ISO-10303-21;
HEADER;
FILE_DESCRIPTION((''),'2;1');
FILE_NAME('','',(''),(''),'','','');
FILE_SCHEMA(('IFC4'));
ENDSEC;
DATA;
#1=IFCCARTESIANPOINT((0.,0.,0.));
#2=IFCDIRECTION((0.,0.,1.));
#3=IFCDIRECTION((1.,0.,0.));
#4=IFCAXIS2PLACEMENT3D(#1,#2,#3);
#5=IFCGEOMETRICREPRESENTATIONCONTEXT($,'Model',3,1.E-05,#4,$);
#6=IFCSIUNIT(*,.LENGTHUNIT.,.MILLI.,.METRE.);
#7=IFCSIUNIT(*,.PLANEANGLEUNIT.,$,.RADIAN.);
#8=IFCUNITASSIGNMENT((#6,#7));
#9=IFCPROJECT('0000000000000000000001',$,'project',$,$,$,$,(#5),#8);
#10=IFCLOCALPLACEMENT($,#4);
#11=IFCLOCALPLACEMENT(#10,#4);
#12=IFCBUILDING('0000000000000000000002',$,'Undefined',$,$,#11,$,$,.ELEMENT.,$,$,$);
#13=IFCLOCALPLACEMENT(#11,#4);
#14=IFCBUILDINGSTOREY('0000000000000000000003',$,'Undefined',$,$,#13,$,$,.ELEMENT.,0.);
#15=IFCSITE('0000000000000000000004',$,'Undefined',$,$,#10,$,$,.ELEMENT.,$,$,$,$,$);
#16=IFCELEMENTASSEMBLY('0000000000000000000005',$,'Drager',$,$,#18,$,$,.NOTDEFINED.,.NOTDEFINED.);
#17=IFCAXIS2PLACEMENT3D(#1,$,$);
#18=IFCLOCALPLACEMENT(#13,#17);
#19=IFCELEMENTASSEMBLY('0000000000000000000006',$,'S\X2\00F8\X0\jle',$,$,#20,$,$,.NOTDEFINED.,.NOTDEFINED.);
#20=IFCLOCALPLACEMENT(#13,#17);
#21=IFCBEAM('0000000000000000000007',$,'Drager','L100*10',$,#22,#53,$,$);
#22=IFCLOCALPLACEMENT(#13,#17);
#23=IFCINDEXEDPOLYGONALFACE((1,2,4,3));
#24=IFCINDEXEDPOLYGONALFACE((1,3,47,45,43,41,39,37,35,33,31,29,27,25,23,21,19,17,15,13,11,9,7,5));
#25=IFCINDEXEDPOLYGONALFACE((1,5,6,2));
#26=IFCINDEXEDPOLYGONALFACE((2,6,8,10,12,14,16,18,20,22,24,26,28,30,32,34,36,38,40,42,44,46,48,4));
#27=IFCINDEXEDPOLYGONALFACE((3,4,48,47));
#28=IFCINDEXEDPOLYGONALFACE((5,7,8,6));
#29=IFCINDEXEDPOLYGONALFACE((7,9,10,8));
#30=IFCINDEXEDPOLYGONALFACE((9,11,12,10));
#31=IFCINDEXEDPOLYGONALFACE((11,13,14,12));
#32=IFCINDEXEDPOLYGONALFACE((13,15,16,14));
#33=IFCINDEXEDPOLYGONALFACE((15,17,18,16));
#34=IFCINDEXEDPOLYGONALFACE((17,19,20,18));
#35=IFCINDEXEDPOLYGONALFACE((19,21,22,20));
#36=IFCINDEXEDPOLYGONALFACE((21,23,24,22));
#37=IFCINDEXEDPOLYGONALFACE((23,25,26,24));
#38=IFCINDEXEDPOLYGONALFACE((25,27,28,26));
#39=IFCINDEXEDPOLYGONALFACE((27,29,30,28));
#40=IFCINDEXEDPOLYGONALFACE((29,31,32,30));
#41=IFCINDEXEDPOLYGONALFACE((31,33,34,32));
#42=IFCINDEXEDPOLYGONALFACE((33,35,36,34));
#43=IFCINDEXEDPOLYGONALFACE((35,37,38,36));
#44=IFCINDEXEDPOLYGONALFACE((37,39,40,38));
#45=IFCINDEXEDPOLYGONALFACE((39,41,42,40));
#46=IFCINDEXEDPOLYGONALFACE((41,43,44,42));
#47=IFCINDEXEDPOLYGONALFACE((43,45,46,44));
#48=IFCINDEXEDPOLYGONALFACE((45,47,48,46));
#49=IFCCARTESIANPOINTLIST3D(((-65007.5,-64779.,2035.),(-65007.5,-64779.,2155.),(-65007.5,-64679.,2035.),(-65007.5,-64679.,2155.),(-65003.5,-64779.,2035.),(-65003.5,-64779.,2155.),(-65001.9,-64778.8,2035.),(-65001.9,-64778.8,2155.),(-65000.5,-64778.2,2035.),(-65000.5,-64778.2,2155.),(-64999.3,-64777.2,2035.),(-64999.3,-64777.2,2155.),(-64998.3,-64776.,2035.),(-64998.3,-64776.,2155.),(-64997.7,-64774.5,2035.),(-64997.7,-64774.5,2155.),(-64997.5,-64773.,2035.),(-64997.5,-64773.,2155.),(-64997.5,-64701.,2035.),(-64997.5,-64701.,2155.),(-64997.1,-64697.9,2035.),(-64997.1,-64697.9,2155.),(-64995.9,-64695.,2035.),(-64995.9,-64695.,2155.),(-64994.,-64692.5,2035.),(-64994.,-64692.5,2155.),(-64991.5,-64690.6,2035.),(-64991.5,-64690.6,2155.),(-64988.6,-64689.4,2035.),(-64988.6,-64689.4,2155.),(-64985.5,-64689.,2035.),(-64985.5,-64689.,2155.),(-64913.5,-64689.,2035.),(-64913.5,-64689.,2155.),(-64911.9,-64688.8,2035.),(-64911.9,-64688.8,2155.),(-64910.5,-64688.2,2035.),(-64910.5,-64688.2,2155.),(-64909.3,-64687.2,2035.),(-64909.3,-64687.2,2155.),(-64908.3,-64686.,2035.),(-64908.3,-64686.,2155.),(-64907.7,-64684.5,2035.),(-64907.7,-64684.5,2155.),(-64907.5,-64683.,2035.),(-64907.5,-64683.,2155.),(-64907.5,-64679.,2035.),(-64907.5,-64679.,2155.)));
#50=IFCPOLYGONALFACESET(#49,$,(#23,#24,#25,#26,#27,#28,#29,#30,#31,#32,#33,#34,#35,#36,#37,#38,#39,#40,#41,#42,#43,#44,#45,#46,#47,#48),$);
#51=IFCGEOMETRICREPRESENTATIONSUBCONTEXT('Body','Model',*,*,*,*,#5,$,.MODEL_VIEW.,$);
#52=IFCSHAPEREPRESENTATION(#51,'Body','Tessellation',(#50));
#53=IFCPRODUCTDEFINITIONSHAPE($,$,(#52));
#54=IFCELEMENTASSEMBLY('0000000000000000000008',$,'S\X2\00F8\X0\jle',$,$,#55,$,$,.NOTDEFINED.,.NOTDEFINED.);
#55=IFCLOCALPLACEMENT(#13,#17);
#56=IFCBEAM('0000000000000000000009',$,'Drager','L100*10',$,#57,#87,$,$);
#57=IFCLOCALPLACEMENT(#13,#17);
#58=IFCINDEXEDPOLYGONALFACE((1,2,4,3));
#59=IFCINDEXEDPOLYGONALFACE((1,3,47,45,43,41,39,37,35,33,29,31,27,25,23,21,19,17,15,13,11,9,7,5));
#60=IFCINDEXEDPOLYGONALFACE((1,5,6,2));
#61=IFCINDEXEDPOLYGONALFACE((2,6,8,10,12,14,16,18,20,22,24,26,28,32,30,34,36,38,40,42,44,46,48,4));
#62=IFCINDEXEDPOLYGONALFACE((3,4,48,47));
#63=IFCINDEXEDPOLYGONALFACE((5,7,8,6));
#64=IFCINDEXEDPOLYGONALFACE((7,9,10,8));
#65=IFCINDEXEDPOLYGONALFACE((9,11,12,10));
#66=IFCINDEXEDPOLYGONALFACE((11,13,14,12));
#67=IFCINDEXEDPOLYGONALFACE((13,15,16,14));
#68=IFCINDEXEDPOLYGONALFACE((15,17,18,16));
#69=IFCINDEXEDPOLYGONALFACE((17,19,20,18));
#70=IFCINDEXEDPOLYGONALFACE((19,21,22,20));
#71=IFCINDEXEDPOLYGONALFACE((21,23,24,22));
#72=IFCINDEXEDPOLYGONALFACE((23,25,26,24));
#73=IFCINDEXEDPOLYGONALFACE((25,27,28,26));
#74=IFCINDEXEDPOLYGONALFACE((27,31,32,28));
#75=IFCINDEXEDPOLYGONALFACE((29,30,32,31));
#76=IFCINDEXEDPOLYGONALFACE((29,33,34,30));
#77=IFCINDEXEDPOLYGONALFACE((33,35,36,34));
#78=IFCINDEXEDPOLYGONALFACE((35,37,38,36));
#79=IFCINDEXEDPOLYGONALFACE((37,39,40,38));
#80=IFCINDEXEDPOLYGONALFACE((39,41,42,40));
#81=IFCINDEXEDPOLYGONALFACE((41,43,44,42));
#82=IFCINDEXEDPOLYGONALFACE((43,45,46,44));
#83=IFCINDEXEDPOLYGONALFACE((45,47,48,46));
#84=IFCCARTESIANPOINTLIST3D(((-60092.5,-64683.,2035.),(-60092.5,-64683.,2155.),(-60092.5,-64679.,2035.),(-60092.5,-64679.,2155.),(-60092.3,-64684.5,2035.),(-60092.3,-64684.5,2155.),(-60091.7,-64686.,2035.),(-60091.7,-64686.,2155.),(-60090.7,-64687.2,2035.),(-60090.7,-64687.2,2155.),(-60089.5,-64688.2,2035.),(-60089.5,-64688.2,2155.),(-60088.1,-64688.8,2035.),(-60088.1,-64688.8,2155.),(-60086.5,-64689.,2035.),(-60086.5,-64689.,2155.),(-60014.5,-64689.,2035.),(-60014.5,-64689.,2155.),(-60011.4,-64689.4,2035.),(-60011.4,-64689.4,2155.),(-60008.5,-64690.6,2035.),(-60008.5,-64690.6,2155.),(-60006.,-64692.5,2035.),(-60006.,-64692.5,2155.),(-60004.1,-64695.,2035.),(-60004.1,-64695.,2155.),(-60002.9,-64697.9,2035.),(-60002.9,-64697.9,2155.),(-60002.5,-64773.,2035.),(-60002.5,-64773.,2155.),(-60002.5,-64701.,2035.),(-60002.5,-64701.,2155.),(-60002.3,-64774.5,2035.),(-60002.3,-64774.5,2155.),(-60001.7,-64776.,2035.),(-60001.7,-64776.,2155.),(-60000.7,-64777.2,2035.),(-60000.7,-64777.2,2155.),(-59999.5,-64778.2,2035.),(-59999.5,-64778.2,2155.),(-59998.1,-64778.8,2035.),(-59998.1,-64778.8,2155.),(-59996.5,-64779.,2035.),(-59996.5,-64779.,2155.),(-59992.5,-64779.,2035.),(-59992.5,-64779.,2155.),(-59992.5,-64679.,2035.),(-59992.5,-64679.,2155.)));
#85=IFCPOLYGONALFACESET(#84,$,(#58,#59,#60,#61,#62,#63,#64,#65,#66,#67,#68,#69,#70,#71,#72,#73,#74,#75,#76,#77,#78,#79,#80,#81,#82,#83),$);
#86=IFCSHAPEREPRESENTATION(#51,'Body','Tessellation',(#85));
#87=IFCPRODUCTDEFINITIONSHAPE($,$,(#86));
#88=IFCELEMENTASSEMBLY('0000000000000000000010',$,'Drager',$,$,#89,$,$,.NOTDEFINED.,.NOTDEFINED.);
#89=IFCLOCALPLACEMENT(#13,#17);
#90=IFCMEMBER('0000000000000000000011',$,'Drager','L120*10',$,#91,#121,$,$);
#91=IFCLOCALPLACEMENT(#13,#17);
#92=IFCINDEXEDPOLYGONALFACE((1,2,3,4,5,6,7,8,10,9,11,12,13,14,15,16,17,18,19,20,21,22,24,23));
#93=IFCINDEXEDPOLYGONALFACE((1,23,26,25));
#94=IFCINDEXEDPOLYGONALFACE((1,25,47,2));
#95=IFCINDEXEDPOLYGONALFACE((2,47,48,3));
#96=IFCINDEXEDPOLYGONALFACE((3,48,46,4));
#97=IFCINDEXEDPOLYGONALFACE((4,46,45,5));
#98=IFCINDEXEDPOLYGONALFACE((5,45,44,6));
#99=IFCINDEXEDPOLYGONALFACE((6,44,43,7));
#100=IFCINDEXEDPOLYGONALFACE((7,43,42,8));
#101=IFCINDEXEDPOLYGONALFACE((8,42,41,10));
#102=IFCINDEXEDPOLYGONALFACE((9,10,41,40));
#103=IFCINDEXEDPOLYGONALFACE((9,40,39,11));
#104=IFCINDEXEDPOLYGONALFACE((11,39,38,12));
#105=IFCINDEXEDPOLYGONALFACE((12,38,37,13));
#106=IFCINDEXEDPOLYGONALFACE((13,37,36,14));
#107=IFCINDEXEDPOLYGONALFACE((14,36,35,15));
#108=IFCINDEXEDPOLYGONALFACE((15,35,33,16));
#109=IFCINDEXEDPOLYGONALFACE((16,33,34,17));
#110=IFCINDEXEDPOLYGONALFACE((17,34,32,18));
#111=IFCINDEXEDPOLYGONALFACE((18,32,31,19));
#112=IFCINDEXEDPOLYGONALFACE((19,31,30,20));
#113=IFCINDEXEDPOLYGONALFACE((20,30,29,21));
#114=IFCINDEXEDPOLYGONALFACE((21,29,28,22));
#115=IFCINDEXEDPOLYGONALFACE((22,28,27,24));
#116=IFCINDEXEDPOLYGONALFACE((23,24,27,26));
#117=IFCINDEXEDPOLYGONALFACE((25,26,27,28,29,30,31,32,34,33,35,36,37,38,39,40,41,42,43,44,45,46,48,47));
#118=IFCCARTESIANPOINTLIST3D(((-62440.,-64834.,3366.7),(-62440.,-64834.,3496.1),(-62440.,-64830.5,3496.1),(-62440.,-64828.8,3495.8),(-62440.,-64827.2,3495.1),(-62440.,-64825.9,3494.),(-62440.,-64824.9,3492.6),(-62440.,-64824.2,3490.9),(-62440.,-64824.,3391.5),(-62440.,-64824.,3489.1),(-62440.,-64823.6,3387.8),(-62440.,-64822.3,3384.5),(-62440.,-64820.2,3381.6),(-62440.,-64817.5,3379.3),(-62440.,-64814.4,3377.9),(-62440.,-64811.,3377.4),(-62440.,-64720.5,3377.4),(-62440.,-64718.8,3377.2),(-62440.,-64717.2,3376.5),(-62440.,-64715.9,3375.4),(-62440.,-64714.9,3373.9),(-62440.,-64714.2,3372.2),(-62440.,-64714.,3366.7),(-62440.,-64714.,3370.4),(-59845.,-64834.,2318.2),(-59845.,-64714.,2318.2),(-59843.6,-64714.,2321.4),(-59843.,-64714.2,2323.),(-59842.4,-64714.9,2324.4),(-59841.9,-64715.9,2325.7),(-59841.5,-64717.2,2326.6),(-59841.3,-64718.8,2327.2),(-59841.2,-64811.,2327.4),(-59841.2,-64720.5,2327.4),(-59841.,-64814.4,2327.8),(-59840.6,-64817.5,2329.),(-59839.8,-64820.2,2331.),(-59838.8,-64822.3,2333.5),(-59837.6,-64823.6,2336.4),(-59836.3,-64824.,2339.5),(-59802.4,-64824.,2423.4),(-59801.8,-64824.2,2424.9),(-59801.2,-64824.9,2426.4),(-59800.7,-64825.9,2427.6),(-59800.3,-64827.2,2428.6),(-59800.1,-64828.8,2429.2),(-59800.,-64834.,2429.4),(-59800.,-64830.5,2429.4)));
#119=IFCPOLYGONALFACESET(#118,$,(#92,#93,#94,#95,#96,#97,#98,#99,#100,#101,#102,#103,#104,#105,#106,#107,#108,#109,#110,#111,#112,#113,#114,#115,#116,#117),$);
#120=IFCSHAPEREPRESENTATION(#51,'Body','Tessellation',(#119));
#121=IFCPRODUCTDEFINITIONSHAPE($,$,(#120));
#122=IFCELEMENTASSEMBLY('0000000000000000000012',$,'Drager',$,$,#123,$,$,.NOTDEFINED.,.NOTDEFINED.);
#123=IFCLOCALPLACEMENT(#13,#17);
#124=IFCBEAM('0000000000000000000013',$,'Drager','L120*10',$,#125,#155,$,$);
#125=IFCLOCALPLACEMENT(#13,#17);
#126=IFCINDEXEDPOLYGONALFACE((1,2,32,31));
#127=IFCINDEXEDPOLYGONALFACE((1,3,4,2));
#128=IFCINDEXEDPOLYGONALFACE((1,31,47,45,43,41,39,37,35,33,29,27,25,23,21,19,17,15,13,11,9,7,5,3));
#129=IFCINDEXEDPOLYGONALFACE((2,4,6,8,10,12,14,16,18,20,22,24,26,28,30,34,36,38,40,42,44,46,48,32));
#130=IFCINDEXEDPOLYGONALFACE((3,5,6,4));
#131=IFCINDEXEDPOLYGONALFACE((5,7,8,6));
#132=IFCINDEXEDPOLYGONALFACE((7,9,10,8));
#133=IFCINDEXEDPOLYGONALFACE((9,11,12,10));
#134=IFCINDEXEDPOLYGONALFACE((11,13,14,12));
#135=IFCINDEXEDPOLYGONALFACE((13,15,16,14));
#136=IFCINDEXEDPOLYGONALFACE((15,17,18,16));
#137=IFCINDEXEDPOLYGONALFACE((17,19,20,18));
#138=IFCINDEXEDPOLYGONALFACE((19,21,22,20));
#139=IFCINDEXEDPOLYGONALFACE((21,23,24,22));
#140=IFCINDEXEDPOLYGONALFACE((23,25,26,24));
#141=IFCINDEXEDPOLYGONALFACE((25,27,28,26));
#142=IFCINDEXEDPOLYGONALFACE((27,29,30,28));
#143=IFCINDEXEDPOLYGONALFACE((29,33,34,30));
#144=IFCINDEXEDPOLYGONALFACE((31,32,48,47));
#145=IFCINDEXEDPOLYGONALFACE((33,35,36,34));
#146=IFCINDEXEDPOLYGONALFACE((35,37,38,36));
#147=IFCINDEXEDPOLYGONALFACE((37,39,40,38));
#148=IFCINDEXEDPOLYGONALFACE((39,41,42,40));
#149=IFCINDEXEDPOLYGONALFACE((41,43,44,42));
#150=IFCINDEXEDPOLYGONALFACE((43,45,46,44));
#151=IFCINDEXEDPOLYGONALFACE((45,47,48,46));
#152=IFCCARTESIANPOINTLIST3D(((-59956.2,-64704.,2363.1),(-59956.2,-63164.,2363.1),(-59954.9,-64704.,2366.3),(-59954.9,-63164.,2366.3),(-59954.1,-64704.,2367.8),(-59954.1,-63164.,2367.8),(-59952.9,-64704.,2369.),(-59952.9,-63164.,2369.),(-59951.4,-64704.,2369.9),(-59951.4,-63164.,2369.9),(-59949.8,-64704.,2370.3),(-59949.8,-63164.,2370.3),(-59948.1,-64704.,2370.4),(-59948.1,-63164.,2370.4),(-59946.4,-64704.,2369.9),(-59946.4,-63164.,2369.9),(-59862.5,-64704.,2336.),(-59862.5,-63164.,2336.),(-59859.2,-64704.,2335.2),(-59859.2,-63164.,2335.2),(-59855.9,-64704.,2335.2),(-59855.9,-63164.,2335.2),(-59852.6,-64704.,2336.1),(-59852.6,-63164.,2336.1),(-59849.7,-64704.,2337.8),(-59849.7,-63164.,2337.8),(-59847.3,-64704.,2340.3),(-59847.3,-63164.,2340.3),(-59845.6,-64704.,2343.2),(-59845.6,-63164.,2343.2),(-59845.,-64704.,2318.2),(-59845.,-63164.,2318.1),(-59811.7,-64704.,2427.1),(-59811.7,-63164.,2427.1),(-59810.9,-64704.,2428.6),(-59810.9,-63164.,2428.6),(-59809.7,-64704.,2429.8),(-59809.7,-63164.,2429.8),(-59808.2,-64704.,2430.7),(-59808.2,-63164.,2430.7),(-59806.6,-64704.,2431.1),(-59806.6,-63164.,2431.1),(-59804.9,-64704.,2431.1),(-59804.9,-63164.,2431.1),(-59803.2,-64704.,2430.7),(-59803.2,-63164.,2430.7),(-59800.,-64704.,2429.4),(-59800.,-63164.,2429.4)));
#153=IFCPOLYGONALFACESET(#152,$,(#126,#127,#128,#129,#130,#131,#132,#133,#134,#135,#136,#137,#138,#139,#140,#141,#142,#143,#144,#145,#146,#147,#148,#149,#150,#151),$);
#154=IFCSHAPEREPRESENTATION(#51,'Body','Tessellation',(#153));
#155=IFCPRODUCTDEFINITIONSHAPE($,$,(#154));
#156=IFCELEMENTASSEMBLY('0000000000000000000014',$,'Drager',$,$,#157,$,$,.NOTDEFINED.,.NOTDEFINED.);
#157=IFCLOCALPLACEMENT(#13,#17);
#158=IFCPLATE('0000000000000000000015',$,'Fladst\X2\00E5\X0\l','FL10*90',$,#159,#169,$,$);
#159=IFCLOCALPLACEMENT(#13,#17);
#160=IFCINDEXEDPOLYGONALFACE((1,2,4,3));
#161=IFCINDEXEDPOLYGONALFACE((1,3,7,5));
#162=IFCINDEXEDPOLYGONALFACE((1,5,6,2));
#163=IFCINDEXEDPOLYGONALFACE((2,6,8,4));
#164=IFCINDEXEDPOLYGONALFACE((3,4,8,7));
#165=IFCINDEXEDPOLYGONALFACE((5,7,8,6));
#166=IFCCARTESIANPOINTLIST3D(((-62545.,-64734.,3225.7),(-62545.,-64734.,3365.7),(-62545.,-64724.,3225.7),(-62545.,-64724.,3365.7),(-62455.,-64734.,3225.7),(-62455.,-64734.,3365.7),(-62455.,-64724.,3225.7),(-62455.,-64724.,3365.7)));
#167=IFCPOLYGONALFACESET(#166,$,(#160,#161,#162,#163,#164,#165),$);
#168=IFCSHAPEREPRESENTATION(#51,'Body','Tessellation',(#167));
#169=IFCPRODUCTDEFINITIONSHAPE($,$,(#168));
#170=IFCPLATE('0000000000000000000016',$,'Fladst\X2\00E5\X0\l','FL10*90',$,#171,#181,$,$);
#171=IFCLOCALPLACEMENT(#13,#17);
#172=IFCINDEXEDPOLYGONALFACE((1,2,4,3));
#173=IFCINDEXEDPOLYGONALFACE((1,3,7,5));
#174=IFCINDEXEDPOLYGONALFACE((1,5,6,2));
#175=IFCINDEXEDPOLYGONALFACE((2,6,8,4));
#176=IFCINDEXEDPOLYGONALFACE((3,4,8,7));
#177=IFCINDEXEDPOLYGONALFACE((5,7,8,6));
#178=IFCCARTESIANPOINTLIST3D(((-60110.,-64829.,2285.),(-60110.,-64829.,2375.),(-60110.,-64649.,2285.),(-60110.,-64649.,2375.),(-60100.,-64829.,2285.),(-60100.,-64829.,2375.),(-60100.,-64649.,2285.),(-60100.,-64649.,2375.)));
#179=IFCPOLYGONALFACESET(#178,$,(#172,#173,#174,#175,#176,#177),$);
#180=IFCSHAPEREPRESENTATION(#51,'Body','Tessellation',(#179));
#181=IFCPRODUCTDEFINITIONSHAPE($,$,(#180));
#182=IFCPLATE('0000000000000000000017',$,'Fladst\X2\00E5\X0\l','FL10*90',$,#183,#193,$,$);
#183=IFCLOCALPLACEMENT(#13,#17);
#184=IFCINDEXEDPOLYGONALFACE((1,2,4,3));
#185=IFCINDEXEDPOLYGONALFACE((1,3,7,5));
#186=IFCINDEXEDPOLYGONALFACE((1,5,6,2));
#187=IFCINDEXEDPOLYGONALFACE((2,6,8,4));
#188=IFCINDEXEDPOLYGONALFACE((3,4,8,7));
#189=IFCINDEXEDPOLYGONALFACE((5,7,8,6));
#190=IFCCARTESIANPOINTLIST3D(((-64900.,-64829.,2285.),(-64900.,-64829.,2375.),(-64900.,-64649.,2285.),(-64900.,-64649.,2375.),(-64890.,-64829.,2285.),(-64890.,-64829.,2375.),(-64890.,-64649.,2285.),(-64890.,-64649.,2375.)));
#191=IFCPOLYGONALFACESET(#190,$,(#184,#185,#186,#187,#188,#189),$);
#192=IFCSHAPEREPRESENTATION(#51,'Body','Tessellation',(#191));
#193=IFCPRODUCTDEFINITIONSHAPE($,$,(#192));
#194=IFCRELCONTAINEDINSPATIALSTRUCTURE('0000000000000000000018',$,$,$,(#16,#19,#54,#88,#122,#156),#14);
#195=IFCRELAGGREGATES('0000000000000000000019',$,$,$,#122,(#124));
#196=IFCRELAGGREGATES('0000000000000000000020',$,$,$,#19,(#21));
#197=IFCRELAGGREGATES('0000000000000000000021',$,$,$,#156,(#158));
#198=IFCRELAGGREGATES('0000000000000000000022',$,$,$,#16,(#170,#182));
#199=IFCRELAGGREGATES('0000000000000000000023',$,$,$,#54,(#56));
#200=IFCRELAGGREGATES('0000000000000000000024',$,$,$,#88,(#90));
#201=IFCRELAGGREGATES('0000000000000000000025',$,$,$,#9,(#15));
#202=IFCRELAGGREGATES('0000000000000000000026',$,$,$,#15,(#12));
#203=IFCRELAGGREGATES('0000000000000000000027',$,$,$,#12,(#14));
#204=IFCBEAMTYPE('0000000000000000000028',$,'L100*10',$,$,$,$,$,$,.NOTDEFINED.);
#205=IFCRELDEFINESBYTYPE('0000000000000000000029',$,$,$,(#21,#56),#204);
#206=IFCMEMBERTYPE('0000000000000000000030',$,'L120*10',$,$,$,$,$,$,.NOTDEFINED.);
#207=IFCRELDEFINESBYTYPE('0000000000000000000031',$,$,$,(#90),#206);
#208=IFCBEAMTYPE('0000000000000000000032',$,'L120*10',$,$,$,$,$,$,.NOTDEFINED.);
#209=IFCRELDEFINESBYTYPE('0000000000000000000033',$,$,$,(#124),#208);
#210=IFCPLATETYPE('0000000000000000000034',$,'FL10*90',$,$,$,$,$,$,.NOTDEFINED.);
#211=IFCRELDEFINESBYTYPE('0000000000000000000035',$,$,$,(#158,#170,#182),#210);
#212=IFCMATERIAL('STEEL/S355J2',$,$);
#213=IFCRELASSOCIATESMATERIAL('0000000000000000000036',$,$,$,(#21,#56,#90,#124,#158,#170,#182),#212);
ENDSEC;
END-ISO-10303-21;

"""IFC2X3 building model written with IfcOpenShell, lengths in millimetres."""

from ifc_helpers import new_model, si_unit, frame, origin_with_axes, origin_2d_with_axis, place, context, subcontext, project, spatial, polyline, l_section, outline, extrude, clip, halfspace, material, type_object, element, aggregate, save


model = new_model("IFC2X3")

# Units and contexts
model_context = context("Model", 3, precision=1e-05, world=origin_with_axes())
body_context = subcontext(model_context, "Body", "Model", "MODEL_VIEW")
ifc_project = project(units=[si_unit("LENGTHUNIT", "METRE", prefix="MILLI"), si_unit("PLANEANGLEUNIT", "RADIAN")], contexts=[model_context])

# Site, building, storey
site_placement = place(None, origin_with_axes())
site = spatial("IfcSite", under=ifc_project, at=site_placement, Name="Undefined", CompositionType="ELEMENT")
building_placement = place(site_placement, origin_with_axes())
building = spatial("IfcBuilding", under=site, at=building_placement, Name="Undefined", CompositionType="ELEMENT")
storey_placement = place(building_placement, origin_with_axes())
storey = spatial("IfcBuildingStorey", under=building, at=storey_placement, Name="Undefined", CompositionType="ELEMENT", Elevation=0.0)

# Element assemblies, beams
assembly_1_placement = place(storey_placement, origin_with_axes())
assembly_1 = element("IfcElementAssembly", 1, at=assembly_1_placement, inside=storey, Name="Drager", AssemblyPlace="NOTDEFINED", PredefinedType="NOTDEFINED")
assembly_2_placement = place(storey_placement, origin_with_axes())
assembly_2 = element("IfcElementAssembly", 2, at=assembly_2_placement, inside=storey, Name="Søjle", AssemblyPlace="NOTDEFINED", PredefinedType="NOTDEFINED")
ifc_material_1 = material(Name="STEEL/S355J2")
beam_type_1 = type_object("IfcBeamType", Name="L100*10", PredefinedType="NOTDEFINED")
beam_1_placement = place(assembly_2_placement, frame((-64957.5, -64729.0, 2155.0), z_axis=(1.0, 0.0, 0.0), x_axis=(0.0, 0.0, -1.0)))
beam_1 = element("IfcBeam", 3, at=beam_1_placement, type_object=beam_type_1, material=ifc_material_1, Name="Drager", Description="L100*10", context=body_context, shape_type="SweptSolid", body=[
    extrude(l_section(Depth=100.0, Width=100.0, Thickness=10.0, FilletRadius=12.0, EdgeRadius=6.0, at=origin_2d_with_axis()), frame((120.0, 0.0, 0.0), z_axis=(-1.0, 0.0, 0.0), x_axis=(0.0, -1.0, 0.0)), (0.0, 0.0, 1.0), 120.0),
])
assembly_3_placement = place(storey_placement, origin_with_axes())
assembly_3 = element("IfcElementAssembly", 4, at=assembly_3_placement, inside=storey, Name="Søjle", AssemblyPlace="NOTDEFINED", PredefinedType="NOTDEFINED")
beam_2_placement = place(assembly_3_placement, frame((-60042.5, -64729.0, 2035.0), z_axis=(-1.0, 0.0, 0.0), x_axis=(0.0, 0.0, 1.0)))
beam_2 = element("IfcBeam", 5, at=beam_2_placement, type_object=beam_type_1, material=ifc_material_1, Name="Drager", Description="L100*10", context=body_context, shape_type="SweptSolid", body=[
    extrude(l_section(Depth=100.0, Width=100.0, Thickness=10.0, FilletRadius=12.0, EdgeRadius=6.0, at=origin_2d_with_axis()), frame((120.0, 0.0, 0.0), z_axis=(-1.0, 0.0, 0.0), x_axis=(0.0, -1.0, 0.0)), (0.0, 0.0, 1.0), 120.0),
])

# Element assembly, member
assembly_4_placement = place(storey_placement, origin_with_axes())
assembly_4 = element("IfcElementAssembly", 6, at=assembly_4_placement, inside=storey, Name="Drager", AssemblyPlace="NOTDEFINED", PredefinedType="NOTDEFINED")
member_type = type_object("IfcMemberType", Name="L120*10", PredefinedType="NOTDEFINED")
member_placement = place(assembly_4_placement, frame((-62494.1, -64774.0, 3453.2), z_axis=(0.0, 1.0, 0.0), x_axis=(0.927179, 0.0, -0.374619)))
member = element("IfcMember", 7, at=member_placement, type_object=member_type, material=ifc_material_1, Name="Drager", Description="L120*10", context=body_context, shape_type="Clipping", body=[
    clip(clip(extrude(l_section(Depth=120.0, Width=120.0, Thickness=10.0, FilletRadius=13.0, EdgeRadius=6.5, at=origin_2d_with_axis()), frame((2948.0, 0.0, 0.0), z_axis=(-1.0, 0.0, 0.0), x_axis=(0.0, -1.0, 0.0)), (0.0, 0.0, 1.0), 2956.3), halfspace(frame((2881.4, 0.0, -60.0), z_axis=(-1.0, 0.0, 0.0), x_axis=(0.0, 1.0, 0.0)), True)), halfspace(frame((81.0, 56.3, -1.0), z_axis=(0.927179, -0.374619, 0.0), x_axis=(-0.374619, -0.927179, 0.0)), True)),
])

# Element assembly, beam
assembly_5_placement = place(storey_placement, origin_with_axes())
assembly_5 = element("IfcElementAssembly", 8, at=assembly_5_placement, inside=storey, Name="Drager", AssemblyPlace="NOTDEFINED", PredefinedType="NOTDEFINED")
beam_type_2 = type_object("IfcBeamType", Name="L120*10", PredefinedType="NOTDEFINED")
beam_3_placement = place(assembly_5_placement, frame((-59878.1, -64704.0, 2396.3), z_axis=(-0.927184, 0.0, 0.374607), x_axis=(0.0, 1.0, 0.0)))
beam_3 = element("IfcBeam", 9, at=beam_3_placement, type_object=beam_type_2, material=ifc_material_1, Name="Drager", Description="L120*10", context=body_context, shape_type="SweptSolid", body=[
    extrude(l_section(Depth=120.0, Width=120.0, Thickness=10.0, FilletRadius=13.0, EdgeRadius=6.5, at=origin_2d_with_axis()), frame((1540.0, 0.0, 0.0), z_axis=(-1.0, 0.0, 0.0), x_axis=(0.0, -1.0, 0.0)), (0.0, 0.0, 1.0), 1540.0),
])
aggregate(assembly_5, [beam_3])

# Element assembly, plate
assembly_6_placement = place(storey_placement, origin_with_axes())
assembly_6 = element("IfcElementAssembly", 10, at=assembly_6_placement, inside=storey, Name="Drager", AssemblyPlace="NOTDEFINED", PredefinedType="NOTDEFINED")
plate_type_1 = type_object("IfcPlateType", Name="FL10*90", PredefinedType="NOTDEFINED")
plate_1_placement = place(assembly_6_placement, frame((-62500.0, -64729.0, 3365.7), z_axis=(0.0, 1.0, 0.0), x_axis=(0.0, 0.0, -1.0)))
plate_1 = element("IfcPlate", 11, at=plate_1_placement, type_object=plate_type_1, material=ifc_material_1, Name="Fladstål", Description="FL10*90", context=body_context, shape_type="SweptSolid", body=[
    extrude(outline(polyline([(0.0, -45.0), (0.0, 45.0), (140.0, 45.0), (140.0, -45.0), (0.0, -45.0)])), frame((0.0, 0.0, -5.0), z_axis=(0.0, 0.0, 1.0), x_axis=(1.0, 0.0, 0.0)), (0.0, 0.0, 1.0), 10.0),
])

# Plates
plate_2_placement = place(assembly_1_placement, frame((-60105.0, -64829.0, 2330.0), z_axis=(-1.0, 0.0, 0.0), x_axis=(0.0, 1.0, 0.0)))
plate_2 = element("IfcPlate", 12, at=plate_2_placement, type_object=plate_type_1, material=ifc_material_1, Name="Fladstål", Description="FL10*90", context=body_context, shape_type="SweptSolid", body=[
    extrude(outline(polyline([(0.0, -45.0), (0.0, 45.0), (180.0, 45.0), (180.0, -45.0), (0.0, -45.0)])), frame((0.0, 0.0, -5.0), z_axis=(0.0, 0.0, 1.0), x_axis=(1.0, 0.0, 0.0)), (0.0, 0.0, 1.0), 10.0),
])
plate_3_placement = place(assembly_1_placement, frame((-64895.0, -64829.0, 2330.0), z_axis=(1.0, 0.0, 0.0), x_axis=(0.0, 1.0, 0.0)))
plate_3 = element("IfcPlate", 13, at=plate_3_placement, type_object=plate_type_1, material=ifc_material_1, Name="Fladstål", Description="FL10*90", context=body_context, shape_type="SweptSolid", body=[
    extrude(outline(polyline([(0.0, -45.0), (0.0, 45.0), (180.0, 45.0), (180.0, -45.0), (0.0, -45.0)])), frame((0.0, 0.0, -5.0), z_axis=(0.0, 0.0, 1.0), x_axis=(1.0, 0.0, 0.0)), (0.0, 0.0, 1.0), 10.0),
])
aggregate(assembly_2, [beam_1])

aggregate(assembly_6, [plate_1])
aggregate(assembly_1, [plate_2, plate_3])
aggregate(assembly_3, [beam_2])
aggregate(assembly_4, [member])

save(model, "model.ifc")
